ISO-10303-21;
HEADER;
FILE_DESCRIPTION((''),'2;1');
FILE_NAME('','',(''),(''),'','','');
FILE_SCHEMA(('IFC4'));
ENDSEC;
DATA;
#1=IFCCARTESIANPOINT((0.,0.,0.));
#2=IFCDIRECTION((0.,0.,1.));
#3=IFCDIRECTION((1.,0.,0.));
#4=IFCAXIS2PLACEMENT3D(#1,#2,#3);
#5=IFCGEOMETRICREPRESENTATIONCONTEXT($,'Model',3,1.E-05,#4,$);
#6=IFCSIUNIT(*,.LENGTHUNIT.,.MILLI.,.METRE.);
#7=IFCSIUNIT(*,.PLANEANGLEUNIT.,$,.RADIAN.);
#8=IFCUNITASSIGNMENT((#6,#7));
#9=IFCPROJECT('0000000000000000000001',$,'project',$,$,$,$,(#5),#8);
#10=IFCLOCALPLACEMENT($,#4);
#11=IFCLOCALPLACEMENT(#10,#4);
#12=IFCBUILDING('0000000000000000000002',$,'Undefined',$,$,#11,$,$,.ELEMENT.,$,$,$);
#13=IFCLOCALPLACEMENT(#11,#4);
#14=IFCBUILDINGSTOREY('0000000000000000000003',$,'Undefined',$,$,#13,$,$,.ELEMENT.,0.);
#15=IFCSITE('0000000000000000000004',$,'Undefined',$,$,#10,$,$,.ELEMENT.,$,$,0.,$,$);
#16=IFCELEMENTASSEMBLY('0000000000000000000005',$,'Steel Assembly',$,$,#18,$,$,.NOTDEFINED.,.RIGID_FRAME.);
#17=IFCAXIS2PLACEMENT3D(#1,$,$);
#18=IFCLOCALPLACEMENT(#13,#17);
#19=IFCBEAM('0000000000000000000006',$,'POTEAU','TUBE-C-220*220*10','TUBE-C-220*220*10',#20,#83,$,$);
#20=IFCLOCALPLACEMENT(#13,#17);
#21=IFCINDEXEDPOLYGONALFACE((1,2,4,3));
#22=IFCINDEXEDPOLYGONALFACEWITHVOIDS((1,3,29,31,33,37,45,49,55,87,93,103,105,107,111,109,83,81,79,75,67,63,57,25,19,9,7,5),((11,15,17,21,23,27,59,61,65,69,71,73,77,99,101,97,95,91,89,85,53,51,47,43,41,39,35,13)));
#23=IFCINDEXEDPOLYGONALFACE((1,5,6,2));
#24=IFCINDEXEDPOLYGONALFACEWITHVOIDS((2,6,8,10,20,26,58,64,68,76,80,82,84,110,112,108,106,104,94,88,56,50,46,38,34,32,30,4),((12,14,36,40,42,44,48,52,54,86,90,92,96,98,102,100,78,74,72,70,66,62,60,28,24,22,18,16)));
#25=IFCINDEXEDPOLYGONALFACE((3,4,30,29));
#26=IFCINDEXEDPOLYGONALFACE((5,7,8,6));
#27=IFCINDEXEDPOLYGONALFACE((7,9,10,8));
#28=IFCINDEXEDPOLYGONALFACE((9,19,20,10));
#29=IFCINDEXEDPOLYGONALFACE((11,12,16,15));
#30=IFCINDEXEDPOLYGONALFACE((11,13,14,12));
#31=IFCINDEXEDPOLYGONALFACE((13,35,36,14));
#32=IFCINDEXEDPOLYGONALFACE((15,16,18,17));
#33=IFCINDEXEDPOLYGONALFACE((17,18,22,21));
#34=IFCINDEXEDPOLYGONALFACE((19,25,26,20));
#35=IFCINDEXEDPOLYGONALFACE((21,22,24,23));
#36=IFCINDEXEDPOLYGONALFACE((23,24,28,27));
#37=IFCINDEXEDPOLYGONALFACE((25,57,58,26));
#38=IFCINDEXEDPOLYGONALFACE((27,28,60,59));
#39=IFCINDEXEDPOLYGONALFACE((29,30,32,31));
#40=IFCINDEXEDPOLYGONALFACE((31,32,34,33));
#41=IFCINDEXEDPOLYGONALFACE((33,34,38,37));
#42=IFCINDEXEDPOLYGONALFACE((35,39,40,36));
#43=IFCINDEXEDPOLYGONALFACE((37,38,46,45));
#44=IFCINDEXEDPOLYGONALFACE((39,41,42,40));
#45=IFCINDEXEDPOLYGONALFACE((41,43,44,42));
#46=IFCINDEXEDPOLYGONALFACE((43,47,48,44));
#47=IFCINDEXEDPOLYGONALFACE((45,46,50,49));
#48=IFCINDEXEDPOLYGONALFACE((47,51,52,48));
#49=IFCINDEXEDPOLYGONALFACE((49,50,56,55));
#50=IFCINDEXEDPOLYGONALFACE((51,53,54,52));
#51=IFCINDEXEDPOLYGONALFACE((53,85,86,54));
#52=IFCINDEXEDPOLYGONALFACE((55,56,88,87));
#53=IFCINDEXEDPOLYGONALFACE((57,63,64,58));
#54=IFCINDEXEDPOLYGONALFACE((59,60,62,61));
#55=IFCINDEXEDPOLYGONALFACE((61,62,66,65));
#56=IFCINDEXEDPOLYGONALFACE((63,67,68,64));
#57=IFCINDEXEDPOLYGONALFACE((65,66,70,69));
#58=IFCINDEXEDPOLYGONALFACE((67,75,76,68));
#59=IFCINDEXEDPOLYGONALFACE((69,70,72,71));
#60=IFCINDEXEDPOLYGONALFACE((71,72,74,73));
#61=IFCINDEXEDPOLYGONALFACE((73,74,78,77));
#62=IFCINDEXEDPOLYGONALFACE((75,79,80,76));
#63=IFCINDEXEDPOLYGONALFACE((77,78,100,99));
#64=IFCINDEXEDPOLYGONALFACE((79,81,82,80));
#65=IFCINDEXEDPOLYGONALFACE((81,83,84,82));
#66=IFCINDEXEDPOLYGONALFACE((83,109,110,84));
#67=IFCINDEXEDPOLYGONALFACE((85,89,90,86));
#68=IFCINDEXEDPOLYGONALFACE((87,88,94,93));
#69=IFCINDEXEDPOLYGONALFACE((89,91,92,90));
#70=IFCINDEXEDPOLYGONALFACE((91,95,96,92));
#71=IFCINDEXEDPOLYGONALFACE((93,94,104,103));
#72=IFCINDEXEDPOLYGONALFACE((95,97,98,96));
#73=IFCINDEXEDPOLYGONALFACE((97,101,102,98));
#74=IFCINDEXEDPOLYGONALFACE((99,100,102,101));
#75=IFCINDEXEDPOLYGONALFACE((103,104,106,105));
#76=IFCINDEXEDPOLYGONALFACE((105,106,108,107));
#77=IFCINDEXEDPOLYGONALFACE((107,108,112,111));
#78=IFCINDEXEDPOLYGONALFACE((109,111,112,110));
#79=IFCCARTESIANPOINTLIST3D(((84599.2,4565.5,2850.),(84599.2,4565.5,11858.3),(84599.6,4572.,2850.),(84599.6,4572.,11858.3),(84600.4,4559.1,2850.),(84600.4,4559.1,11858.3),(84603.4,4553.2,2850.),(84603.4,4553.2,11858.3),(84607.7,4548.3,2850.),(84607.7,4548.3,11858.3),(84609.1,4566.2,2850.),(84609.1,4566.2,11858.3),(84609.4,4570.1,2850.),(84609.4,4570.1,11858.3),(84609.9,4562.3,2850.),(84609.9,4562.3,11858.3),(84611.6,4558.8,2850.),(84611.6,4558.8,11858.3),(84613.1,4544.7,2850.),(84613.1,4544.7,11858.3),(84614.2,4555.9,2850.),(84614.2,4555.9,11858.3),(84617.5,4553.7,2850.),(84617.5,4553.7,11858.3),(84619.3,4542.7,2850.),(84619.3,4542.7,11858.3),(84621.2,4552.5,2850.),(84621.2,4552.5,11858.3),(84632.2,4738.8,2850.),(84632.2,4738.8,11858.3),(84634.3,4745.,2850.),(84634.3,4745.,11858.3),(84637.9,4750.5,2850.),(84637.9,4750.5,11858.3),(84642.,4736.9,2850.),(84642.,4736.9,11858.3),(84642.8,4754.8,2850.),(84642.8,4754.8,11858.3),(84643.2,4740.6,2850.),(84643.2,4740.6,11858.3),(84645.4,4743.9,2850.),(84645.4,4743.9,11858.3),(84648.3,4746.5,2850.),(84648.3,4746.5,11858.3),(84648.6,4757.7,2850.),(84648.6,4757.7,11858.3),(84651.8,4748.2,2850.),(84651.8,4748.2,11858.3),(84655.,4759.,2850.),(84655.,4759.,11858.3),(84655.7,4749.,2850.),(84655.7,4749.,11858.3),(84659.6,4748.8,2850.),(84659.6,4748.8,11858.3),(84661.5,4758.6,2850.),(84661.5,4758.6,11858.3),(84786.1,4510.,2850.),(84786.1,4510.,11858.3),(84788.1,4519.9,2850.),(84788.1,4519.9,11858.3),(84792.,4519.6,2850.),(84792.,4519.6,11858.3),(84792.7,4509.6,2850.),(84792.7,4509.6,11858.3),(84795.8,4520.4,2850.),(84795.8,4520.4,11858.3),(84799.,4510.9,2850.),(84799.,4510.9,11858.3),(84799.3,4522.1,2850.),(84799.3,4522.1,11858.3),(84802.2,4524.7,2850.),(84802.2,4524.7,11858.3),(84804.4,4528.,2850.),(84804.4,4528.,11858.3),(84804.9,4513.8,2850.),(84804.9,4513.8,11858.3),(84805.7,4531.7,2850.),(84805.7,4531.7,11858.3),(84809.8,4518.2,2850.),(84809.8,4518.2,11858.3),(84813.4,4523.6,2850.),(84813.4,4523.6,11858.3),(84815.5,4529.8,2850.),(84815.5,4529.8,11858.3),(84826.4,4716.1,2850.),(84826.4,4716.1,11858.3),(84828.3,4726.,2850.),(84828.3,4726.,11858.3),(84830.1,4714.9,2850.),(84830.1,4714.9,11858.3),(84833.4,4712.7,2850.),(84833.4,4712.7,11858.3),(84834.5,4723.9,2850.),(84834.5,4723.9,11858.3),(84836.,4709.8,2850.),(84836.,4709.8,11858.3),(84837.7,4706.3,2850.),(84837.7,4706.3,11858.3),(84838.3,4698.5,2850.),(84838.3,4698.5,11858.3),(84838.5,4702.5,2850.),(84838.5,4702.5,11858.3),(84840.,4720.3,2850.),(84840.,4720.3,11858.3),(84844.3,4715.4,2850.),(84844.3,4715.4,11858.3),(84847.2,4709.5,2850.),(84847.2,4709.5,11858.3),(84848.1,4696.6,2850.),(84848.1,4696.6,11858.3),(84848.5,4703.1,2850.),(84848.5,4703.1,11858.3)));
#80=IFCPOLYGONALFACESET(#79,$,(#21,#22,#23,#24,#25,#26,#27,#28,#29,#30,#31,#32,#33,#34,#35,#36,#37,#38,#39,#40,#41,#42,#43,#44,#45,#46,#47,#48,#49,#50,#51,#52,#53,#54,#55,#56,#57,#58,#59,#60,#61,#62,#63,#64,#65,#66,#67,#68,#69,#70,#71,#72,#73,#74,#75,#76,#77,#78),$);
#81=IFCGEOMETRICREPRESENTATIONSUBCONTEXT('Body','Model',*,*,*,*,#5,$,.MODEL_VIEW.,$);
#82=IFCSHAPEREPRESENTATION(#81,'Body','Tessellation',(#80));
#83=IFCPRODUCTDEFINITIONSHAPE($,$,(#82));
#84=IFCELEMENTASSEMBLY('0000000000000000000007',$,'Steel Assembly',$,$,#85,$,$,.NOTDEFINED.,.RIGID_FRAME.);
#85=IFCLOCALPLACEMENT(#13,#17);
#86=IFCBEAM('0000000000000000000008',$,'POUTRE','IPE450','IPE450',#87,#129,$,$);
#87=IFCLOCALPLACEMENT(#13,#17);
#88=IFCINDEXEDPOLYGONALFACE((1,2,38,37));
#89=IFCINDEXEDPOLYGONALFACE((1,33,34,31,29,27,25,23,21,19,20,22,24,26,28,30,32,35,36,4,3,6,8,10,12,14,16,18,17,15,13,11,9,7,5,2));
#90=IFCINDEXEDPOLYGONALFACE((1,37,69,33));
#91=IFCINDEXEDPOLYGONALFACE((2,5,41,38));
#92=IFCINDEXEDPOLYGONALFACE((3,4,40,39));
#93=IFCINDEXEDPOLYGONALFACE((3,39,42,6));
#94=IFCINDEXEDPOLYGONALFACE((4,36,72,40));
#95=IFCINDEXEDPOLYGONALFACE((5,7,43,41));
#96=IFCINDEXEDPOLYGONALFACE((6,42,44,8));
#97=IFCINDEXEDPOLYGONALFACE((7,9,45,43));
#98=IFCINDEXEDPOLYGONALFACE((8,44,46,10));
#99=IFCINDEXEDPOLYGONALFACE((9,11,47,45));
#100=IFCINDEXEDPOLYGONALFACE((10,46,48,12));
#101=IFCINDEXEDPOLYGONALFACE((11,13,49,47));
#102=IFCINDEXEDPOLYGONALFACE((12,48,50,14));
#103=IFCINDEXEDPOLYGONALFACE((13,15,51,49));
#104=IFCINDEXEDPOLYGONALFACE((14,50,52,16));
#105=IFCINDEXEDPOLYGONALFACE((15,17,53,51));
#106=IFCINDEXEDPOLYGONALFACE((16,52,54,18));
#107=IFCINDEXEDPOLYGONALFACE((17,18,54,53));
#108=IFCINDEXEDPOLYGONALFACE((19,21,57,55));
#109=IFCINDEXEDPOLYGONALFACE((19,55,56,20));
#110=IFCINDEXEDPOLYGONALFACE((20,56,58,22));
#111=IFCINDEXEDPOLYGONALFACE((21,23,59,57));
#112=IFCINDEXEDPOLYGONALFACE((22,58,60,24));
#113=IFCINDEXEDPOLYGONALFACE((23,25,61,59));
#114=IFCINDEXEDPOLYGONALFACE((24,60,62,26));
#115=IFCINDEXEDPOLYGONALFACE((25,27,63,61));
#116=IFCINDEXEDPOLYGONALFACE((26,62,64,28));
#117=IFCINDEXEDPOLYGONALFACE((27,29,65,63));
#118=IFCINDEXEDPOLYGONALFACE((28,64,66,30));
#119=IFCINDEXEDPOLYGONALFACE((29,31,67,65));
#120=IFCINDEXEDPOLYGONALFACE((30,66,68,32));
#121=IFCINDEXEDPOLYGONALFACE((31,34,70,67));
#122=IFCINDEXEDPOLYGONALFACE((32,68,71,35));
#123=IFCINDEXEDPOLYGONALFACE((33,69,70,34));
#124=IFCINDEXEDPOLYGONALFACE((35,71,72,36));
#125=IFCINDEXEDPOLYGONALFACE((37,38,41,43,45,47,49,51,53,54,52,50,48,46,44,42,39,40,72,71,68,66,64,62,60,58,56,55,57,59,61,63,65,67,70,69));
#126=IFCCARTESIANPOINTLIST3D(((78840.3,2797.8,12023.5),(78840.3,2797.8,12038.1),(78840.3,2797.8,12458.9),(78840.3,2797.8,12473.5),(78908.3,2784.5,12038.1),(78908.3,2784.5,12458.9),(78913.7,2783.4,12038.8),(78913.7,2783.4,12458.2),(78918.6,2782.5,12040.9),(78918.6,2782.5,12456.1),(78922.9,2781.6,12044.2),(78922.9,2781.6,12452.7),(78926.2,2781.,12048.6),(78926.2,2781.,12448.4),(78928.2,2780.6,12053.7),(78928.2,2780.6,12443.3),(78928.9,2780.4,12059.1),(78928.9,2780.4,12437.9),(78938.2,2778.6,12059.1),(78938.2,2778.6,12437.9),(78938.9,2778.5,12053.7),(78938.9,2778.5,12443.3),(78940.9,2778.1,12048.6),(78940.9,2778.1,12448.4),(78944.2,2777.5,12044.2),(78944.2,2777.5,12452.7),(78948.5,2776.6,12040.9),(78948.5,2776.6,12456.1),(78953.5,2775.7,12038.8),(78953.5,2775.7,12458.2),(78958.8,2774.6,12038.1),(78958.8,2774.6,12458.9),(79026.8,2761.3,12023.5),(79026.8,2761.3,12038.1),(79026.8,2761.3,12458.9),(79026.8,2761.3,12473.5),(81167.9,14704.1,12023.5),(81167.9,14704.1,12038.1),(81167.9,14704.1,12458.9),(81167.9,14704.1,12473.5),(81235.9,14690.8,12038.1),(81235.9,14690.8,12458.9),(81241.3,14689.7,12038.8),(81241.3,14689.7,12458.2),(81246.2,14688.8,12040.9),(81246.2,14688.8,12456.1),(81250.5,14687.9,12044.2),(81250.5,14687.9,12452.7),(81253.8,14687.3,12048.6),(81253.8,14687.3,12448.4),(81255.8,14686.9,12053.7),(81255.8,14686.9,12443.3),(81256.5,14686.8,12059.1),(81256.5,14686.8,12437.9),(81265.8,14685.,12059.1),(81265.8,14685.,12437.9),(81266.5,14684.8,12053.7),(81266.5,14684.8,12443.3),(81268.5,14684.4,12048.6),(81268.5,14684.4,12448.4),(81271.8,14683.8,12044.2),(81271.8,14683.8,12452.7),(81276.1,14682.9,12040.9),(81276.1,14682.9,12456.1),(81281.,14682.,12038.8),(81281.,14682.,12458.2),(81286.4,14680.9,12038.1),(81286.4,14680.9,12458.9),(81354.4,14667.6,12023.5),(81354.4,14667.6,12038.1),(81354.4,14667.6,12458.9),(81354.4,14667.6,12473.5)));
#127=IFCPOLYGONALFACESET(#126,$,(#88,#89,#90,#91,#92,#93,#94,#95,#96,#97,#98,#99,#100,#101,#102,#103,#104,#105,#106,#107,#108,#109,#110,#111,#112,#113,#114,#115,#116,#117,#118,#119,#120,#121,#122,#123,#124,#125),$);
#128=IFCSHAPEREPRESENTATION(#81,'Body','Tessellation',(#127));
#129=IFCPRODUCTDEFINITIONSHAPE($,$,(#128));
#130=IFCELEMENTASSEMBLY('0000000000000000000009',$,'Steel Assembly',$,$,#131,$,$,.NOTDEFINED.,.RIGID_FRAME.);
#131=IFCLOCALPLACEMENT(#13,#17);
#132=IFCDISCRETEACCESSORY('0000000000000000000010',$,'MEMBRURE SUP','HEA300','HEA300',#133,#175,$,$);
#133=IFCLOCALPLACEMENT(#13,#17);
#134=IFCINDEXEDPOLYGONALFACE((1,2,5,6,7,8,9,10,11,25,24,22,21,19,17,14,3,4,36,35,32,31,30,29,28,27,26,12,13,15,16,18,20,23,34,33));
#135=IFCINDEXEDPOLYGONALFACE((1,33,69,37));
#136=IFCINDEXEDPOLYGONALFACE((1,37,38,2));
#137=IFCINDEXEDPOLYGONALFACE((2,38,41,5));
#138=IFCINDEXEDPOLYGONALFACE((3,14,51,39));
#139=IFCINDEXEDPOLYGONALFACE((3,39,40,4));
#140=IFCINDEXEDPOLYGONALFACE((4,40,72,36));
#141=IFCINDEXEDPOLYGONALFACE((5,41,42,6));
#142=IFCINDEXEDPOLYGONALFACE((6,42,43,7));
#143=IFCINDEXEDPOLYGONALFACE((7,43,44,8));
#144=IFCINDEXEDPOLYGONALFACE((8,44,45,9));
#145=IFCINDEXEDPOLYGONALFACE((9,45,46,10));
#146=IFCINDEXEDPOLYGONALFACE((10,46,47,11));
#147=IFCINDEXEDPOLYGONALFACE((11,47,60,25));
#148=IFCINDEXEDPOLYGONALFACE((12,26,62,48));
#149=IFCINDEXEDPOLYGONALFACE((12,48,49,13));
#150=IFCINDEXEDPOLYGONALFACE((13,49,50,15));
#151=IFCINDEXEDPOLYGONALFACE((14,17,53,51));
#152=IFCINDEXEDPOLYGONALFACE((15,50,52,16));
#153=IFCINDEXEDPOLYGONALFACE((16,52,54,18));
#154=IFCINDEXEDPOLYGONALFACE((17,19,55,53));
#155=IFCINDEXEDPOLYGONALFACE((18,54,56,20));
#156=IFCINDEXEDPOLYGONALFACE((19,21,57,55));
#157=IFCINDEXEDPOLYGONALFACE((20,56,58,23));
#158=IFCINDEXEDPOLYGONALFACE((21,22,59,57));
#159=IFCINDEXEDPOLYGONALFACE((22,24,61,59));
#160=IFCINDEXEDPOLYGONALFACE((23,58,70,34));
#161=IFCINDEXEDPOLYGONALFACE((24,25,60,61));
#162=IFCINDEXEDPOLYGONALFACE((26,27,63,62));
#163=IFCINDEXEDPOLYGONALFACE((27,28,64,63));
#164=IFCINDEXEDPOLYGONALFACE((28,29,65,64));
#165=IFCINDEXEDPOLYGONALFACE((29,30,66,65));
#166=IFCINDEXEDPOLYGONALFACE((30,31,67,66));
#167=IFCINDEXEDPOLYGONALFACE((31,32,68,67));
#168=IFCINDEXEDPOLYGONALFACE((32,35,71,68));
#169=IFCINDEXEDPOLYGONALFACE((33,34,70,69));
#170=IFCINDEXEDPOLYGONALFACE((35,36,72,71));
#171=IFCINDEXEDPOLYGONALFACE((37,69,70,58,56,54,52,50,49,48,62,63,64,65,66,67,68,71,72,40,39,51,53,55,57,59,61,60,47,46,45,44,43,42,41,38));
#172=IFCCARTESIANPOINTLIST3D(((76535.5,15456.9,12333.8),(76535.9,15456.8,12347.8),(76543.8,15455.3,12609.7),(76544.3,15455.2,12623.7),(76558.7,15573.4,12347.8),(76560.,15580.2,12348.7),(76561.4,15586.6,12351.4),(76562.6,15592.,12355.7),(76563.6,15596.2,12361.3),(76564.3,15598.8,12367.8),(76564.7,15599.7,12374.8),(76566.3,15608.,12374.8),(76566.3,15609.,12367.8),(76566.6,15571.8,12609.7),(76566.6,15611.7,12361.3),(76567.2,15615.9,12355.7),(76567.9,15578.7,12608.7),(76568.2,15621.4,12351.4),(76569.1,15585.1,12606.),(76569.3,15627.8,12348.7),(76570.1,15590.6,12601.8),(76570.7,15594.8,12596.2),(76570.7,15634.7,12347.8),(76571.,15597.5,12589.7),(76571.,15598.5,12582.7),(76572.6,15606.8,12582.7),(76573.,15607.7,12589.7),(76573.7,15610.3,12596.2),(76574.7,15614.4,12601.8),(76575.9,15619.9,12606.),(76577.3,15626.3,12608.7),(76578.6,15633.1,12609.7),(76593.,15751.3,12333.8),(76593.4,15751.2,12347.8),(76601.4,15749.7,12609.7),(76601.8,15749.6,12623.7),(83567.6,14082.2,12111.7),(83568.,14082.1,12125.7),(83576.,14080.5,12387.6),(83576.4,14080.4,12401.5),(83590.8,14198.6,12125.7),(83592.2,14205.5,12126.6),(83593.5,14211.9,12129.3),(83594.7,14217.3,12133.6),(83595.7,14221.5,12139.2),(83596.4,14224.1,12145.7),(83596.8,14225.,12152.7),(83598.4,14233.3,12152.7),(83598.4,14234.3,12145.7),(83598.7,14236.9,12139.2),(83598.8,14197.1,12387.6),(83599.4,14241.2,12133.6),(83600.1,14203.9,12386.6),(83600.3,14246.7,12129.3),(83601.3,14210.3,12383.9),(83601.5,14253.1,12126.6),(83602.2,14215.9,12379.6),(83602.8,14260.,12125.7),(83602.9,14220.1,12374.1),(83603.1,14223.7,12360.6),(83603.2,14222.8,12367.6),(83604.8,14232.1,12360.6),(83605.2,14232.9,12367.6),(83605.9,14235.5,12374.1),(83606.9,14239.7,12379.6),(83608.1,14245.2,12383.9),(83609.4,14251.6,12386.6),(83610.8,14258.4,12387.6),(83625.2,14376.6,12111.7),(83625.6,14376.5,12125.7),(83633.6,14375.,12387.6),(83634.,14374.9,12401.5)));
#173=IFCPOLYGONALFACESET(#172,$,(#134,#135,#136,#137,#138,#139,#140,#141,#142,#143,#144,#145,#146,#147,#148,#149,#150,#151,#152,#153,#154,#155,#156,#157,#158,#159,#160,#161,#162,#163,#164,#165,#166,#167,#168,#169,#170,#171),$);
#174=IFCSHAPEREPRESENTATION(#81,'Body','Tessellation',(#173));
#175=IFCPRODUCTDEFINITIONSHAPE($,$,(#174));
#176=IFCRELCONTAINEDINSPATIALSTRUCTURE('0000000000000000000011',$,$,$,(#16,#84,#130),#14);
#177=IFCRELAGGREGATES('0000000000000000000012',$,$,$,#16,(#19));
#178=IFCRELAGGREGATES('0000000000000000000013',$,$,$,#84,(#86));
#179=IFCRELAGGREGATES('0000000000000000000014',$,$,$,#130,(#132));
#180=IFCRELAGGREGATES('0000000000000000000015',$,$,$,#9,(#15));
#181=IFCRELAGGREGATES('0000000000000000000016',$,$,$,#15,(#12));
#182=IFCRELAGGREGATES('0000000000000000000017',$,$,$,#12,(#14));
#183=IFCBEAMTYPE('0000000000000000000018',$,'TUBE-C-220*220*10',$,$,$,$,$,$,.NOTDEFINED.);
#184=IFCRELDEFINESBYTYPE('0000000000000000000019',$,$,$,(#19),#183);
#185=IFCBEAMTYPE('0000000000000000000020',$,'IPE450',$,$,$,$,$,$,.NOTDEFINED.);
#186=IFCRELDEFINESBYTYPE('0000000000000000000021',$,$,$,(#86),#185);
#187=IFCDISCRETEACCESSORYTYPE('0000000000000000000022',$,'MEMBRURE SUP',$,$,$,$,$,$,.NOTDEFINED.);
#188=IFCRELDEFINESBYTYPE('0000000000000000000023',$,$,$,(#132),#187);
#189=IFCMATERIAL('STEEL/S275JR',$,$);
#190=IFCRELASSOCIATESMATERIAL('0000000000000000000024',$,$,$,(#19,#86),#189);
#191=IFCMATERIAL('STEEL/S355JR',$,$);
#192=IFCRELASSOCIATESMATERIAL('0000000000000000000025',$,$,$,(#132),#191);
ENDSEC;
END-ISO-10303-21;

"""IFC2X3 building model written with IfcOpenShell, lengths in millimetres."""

from ifc_helpers import new_model, si_unit, frame, origin_with_axes, origin_2d_with_axis, place, context, subcontext, project, spatial, hollow_rectangle, i_section, extrude, material, type_object, element, aggregate, save


model = new_model("IFC2X3")

# Units and contexts
model_context = context("Model", 3, precision=1e-05, world=origin_with_axes())
body_context = subcontext(model_context, "Body", "Model", "MODEL_VIEW")
ifc_project = project(units=[si_unit("LENGTHUNIT", "METRE", prefix="MILLI"), si_unit("PLANEANGLEUNIT", "RADIAN")], contexts=[model_context])

# Site, building, storey
site_placement = place(None, origin_with_axes())
site = spatial("IfcSite", under=ifc_project, at=site_placement, Name="Undefined", CompositionType="ELEMENT", RefElevation=0.0)
building_placement = place(site_placement, origin_with_axes())
building = spatial("IfcBuilding", under=site, at=building_placement, Name="Undefined", CompositionType="ELEMENT")
storey_placement = place(building_placement, origin_with_axes())
storey = spatial("IfcBuildingStorey", under=building, at=storey_placement, Name="Undefined", CompositionType="ELEMENT", Elevation=0.0)

# Element assemblies, beams
ifc_material_1 = material(Name="STEEL/S275JR")
assembly_1_placement = place(storey_placement, origin_with_axes())
assembly_1 = element("IfcElementAssembly", 1, at=assembly_1_placement, inside=storey, Name="Steel Assembly", AssemblyPlace="NOTDEFINED", PredefinedType="RIGID_FRAME")
beam_type_1 = type_object("IfcBeamType", Name="TUBE-C-220*220*10", PredefinedType="NOTDEFINED")
beam_1_placement = place(assembly_1_placement, frame((84723.8, 4634.3, 11858.3), z_axis=(0.191859, 0.981422, 0.0), x_axis=(0.0, 0.0, -1.0)))
beam_1 = element("IfcBeam", 2, at=beam_1_placement, type_object=beam_type_1, material=ifc_material_1, Name="POTEAU", Description="TUBE-C-220*220*10", ObjectType="TUBE-C-220*220*10", context=body_context, shape_type="SweptSolid", body=[
    extrude(hollow_rectangle(XDim=220.0, YDim=220.0, WallThickness=10.0, InnerFilletRadius=15.0, OuterFilletRadius=25.0, at=origin_2d_with_axis()), frame((9008.3, 0.0, 0.0), z_axis=(-1.0, 0.0, 0.0), x_axis=(0.0, -1.0, 0.0)), (0.0, 0.0, 1.0), 9008.3),
])
aggregate(assembly_1, [beam_1])
assembly_2_placement = place(storey_placement, origin_with_axes())
assembly_2 = element("IfcElementAssembly", 3, at=assembly_2_placement, inside=storey, Name="Steel Assembly", AssemblyPlace="NOTDEFINED", PredefinedType="RIGID_FRAME")
beam_type_2 = type_object("IfcBeamType", Name="IPE450", PredefinedType="NOTDEFINED")
beam_2_placement = place(assembly_2_placement, frame((81261.2, 14685.9, 12248.5), z_axis=(0.0, 0.0, 1.0), x_axis=(-0.19186, -0.981422, 0.0)))
beam_2 = element("IfcBeam", 4, at=beam_2_placement, type_object=beam_type_2, material=ifc_material_1, Name="POUTRE", Description="IPE450", ObjectType="IPE450", context=body_context, shape_type="SweptSolid", body=[
    extrude(i_section(OverallWidth=190.0, OverallDepth=450.0, WebThickness=9.4, FlangeThickness=14.6, FilletRadius=21.0, at=origin_2d_with_axis()), frame((12131.7, 0.0, 0.0), z_axis=(-1.0, 0.0, 0.0), x_axis=(0.0, -1.0, 0.0)), (0.0, 0.0, 1.0), 12131.7),
])
aggregate(assembly_2, [beam_2])

# Element assembly, discrete accessory
assembly_3_placement = place(storey_placement, origin_with_axes())
assembly_3 = element("IfcElementAssembly", 5, at=assembly_3_placement, inside=storey, Name="Steel Assembly", AssemblyPlace="NOTDEFINED", PredefinedType="RIGID_FRAME")
ifc_material_2 = material(Name="STEEL/S355JR")
discrete_accessory_type_1 = type_object("IfcDiscreteAccessoryType", Name="MEMBRURE SUP")
discrete_accessory_1_placement = place(assembly_3_placement, frame((83600.8, 14228.5, 12256.6), z_axis=(0.030408, -0.005945, 0.99952), x_axis=(-0.980951, 0.191767, 0.030984)))
discrete_accessory_1 = element("IfcDiscreteAccessory", 6, at=discrete_accessory_1_placement, type_object=discrete_accessory_type_1, material=ifc_material_2, Name="MEMBRURE SUP", Description="HEA300", ObjectType="HEA300", context=body_context, shape_type="SweptSolid", body=[
    extrude(i_section(OverallWidth=300.0, OverallDepth=290.0, WebThickness=8.5, FlangeThickness=14.0, FilletRadius=27.0, at=origin_2d_with_axis()), frame((7168.7, 0.0, 0.0), z_axis=(-1.0, 0.0, 0.0), x_axis=(0.0, -1.0, 0.0)), (0.0, 0.0, 1.0), 7168.7),
])
aggregate(assembly_3, [discrete_accessory_1])

save(model, "model.ifc")
